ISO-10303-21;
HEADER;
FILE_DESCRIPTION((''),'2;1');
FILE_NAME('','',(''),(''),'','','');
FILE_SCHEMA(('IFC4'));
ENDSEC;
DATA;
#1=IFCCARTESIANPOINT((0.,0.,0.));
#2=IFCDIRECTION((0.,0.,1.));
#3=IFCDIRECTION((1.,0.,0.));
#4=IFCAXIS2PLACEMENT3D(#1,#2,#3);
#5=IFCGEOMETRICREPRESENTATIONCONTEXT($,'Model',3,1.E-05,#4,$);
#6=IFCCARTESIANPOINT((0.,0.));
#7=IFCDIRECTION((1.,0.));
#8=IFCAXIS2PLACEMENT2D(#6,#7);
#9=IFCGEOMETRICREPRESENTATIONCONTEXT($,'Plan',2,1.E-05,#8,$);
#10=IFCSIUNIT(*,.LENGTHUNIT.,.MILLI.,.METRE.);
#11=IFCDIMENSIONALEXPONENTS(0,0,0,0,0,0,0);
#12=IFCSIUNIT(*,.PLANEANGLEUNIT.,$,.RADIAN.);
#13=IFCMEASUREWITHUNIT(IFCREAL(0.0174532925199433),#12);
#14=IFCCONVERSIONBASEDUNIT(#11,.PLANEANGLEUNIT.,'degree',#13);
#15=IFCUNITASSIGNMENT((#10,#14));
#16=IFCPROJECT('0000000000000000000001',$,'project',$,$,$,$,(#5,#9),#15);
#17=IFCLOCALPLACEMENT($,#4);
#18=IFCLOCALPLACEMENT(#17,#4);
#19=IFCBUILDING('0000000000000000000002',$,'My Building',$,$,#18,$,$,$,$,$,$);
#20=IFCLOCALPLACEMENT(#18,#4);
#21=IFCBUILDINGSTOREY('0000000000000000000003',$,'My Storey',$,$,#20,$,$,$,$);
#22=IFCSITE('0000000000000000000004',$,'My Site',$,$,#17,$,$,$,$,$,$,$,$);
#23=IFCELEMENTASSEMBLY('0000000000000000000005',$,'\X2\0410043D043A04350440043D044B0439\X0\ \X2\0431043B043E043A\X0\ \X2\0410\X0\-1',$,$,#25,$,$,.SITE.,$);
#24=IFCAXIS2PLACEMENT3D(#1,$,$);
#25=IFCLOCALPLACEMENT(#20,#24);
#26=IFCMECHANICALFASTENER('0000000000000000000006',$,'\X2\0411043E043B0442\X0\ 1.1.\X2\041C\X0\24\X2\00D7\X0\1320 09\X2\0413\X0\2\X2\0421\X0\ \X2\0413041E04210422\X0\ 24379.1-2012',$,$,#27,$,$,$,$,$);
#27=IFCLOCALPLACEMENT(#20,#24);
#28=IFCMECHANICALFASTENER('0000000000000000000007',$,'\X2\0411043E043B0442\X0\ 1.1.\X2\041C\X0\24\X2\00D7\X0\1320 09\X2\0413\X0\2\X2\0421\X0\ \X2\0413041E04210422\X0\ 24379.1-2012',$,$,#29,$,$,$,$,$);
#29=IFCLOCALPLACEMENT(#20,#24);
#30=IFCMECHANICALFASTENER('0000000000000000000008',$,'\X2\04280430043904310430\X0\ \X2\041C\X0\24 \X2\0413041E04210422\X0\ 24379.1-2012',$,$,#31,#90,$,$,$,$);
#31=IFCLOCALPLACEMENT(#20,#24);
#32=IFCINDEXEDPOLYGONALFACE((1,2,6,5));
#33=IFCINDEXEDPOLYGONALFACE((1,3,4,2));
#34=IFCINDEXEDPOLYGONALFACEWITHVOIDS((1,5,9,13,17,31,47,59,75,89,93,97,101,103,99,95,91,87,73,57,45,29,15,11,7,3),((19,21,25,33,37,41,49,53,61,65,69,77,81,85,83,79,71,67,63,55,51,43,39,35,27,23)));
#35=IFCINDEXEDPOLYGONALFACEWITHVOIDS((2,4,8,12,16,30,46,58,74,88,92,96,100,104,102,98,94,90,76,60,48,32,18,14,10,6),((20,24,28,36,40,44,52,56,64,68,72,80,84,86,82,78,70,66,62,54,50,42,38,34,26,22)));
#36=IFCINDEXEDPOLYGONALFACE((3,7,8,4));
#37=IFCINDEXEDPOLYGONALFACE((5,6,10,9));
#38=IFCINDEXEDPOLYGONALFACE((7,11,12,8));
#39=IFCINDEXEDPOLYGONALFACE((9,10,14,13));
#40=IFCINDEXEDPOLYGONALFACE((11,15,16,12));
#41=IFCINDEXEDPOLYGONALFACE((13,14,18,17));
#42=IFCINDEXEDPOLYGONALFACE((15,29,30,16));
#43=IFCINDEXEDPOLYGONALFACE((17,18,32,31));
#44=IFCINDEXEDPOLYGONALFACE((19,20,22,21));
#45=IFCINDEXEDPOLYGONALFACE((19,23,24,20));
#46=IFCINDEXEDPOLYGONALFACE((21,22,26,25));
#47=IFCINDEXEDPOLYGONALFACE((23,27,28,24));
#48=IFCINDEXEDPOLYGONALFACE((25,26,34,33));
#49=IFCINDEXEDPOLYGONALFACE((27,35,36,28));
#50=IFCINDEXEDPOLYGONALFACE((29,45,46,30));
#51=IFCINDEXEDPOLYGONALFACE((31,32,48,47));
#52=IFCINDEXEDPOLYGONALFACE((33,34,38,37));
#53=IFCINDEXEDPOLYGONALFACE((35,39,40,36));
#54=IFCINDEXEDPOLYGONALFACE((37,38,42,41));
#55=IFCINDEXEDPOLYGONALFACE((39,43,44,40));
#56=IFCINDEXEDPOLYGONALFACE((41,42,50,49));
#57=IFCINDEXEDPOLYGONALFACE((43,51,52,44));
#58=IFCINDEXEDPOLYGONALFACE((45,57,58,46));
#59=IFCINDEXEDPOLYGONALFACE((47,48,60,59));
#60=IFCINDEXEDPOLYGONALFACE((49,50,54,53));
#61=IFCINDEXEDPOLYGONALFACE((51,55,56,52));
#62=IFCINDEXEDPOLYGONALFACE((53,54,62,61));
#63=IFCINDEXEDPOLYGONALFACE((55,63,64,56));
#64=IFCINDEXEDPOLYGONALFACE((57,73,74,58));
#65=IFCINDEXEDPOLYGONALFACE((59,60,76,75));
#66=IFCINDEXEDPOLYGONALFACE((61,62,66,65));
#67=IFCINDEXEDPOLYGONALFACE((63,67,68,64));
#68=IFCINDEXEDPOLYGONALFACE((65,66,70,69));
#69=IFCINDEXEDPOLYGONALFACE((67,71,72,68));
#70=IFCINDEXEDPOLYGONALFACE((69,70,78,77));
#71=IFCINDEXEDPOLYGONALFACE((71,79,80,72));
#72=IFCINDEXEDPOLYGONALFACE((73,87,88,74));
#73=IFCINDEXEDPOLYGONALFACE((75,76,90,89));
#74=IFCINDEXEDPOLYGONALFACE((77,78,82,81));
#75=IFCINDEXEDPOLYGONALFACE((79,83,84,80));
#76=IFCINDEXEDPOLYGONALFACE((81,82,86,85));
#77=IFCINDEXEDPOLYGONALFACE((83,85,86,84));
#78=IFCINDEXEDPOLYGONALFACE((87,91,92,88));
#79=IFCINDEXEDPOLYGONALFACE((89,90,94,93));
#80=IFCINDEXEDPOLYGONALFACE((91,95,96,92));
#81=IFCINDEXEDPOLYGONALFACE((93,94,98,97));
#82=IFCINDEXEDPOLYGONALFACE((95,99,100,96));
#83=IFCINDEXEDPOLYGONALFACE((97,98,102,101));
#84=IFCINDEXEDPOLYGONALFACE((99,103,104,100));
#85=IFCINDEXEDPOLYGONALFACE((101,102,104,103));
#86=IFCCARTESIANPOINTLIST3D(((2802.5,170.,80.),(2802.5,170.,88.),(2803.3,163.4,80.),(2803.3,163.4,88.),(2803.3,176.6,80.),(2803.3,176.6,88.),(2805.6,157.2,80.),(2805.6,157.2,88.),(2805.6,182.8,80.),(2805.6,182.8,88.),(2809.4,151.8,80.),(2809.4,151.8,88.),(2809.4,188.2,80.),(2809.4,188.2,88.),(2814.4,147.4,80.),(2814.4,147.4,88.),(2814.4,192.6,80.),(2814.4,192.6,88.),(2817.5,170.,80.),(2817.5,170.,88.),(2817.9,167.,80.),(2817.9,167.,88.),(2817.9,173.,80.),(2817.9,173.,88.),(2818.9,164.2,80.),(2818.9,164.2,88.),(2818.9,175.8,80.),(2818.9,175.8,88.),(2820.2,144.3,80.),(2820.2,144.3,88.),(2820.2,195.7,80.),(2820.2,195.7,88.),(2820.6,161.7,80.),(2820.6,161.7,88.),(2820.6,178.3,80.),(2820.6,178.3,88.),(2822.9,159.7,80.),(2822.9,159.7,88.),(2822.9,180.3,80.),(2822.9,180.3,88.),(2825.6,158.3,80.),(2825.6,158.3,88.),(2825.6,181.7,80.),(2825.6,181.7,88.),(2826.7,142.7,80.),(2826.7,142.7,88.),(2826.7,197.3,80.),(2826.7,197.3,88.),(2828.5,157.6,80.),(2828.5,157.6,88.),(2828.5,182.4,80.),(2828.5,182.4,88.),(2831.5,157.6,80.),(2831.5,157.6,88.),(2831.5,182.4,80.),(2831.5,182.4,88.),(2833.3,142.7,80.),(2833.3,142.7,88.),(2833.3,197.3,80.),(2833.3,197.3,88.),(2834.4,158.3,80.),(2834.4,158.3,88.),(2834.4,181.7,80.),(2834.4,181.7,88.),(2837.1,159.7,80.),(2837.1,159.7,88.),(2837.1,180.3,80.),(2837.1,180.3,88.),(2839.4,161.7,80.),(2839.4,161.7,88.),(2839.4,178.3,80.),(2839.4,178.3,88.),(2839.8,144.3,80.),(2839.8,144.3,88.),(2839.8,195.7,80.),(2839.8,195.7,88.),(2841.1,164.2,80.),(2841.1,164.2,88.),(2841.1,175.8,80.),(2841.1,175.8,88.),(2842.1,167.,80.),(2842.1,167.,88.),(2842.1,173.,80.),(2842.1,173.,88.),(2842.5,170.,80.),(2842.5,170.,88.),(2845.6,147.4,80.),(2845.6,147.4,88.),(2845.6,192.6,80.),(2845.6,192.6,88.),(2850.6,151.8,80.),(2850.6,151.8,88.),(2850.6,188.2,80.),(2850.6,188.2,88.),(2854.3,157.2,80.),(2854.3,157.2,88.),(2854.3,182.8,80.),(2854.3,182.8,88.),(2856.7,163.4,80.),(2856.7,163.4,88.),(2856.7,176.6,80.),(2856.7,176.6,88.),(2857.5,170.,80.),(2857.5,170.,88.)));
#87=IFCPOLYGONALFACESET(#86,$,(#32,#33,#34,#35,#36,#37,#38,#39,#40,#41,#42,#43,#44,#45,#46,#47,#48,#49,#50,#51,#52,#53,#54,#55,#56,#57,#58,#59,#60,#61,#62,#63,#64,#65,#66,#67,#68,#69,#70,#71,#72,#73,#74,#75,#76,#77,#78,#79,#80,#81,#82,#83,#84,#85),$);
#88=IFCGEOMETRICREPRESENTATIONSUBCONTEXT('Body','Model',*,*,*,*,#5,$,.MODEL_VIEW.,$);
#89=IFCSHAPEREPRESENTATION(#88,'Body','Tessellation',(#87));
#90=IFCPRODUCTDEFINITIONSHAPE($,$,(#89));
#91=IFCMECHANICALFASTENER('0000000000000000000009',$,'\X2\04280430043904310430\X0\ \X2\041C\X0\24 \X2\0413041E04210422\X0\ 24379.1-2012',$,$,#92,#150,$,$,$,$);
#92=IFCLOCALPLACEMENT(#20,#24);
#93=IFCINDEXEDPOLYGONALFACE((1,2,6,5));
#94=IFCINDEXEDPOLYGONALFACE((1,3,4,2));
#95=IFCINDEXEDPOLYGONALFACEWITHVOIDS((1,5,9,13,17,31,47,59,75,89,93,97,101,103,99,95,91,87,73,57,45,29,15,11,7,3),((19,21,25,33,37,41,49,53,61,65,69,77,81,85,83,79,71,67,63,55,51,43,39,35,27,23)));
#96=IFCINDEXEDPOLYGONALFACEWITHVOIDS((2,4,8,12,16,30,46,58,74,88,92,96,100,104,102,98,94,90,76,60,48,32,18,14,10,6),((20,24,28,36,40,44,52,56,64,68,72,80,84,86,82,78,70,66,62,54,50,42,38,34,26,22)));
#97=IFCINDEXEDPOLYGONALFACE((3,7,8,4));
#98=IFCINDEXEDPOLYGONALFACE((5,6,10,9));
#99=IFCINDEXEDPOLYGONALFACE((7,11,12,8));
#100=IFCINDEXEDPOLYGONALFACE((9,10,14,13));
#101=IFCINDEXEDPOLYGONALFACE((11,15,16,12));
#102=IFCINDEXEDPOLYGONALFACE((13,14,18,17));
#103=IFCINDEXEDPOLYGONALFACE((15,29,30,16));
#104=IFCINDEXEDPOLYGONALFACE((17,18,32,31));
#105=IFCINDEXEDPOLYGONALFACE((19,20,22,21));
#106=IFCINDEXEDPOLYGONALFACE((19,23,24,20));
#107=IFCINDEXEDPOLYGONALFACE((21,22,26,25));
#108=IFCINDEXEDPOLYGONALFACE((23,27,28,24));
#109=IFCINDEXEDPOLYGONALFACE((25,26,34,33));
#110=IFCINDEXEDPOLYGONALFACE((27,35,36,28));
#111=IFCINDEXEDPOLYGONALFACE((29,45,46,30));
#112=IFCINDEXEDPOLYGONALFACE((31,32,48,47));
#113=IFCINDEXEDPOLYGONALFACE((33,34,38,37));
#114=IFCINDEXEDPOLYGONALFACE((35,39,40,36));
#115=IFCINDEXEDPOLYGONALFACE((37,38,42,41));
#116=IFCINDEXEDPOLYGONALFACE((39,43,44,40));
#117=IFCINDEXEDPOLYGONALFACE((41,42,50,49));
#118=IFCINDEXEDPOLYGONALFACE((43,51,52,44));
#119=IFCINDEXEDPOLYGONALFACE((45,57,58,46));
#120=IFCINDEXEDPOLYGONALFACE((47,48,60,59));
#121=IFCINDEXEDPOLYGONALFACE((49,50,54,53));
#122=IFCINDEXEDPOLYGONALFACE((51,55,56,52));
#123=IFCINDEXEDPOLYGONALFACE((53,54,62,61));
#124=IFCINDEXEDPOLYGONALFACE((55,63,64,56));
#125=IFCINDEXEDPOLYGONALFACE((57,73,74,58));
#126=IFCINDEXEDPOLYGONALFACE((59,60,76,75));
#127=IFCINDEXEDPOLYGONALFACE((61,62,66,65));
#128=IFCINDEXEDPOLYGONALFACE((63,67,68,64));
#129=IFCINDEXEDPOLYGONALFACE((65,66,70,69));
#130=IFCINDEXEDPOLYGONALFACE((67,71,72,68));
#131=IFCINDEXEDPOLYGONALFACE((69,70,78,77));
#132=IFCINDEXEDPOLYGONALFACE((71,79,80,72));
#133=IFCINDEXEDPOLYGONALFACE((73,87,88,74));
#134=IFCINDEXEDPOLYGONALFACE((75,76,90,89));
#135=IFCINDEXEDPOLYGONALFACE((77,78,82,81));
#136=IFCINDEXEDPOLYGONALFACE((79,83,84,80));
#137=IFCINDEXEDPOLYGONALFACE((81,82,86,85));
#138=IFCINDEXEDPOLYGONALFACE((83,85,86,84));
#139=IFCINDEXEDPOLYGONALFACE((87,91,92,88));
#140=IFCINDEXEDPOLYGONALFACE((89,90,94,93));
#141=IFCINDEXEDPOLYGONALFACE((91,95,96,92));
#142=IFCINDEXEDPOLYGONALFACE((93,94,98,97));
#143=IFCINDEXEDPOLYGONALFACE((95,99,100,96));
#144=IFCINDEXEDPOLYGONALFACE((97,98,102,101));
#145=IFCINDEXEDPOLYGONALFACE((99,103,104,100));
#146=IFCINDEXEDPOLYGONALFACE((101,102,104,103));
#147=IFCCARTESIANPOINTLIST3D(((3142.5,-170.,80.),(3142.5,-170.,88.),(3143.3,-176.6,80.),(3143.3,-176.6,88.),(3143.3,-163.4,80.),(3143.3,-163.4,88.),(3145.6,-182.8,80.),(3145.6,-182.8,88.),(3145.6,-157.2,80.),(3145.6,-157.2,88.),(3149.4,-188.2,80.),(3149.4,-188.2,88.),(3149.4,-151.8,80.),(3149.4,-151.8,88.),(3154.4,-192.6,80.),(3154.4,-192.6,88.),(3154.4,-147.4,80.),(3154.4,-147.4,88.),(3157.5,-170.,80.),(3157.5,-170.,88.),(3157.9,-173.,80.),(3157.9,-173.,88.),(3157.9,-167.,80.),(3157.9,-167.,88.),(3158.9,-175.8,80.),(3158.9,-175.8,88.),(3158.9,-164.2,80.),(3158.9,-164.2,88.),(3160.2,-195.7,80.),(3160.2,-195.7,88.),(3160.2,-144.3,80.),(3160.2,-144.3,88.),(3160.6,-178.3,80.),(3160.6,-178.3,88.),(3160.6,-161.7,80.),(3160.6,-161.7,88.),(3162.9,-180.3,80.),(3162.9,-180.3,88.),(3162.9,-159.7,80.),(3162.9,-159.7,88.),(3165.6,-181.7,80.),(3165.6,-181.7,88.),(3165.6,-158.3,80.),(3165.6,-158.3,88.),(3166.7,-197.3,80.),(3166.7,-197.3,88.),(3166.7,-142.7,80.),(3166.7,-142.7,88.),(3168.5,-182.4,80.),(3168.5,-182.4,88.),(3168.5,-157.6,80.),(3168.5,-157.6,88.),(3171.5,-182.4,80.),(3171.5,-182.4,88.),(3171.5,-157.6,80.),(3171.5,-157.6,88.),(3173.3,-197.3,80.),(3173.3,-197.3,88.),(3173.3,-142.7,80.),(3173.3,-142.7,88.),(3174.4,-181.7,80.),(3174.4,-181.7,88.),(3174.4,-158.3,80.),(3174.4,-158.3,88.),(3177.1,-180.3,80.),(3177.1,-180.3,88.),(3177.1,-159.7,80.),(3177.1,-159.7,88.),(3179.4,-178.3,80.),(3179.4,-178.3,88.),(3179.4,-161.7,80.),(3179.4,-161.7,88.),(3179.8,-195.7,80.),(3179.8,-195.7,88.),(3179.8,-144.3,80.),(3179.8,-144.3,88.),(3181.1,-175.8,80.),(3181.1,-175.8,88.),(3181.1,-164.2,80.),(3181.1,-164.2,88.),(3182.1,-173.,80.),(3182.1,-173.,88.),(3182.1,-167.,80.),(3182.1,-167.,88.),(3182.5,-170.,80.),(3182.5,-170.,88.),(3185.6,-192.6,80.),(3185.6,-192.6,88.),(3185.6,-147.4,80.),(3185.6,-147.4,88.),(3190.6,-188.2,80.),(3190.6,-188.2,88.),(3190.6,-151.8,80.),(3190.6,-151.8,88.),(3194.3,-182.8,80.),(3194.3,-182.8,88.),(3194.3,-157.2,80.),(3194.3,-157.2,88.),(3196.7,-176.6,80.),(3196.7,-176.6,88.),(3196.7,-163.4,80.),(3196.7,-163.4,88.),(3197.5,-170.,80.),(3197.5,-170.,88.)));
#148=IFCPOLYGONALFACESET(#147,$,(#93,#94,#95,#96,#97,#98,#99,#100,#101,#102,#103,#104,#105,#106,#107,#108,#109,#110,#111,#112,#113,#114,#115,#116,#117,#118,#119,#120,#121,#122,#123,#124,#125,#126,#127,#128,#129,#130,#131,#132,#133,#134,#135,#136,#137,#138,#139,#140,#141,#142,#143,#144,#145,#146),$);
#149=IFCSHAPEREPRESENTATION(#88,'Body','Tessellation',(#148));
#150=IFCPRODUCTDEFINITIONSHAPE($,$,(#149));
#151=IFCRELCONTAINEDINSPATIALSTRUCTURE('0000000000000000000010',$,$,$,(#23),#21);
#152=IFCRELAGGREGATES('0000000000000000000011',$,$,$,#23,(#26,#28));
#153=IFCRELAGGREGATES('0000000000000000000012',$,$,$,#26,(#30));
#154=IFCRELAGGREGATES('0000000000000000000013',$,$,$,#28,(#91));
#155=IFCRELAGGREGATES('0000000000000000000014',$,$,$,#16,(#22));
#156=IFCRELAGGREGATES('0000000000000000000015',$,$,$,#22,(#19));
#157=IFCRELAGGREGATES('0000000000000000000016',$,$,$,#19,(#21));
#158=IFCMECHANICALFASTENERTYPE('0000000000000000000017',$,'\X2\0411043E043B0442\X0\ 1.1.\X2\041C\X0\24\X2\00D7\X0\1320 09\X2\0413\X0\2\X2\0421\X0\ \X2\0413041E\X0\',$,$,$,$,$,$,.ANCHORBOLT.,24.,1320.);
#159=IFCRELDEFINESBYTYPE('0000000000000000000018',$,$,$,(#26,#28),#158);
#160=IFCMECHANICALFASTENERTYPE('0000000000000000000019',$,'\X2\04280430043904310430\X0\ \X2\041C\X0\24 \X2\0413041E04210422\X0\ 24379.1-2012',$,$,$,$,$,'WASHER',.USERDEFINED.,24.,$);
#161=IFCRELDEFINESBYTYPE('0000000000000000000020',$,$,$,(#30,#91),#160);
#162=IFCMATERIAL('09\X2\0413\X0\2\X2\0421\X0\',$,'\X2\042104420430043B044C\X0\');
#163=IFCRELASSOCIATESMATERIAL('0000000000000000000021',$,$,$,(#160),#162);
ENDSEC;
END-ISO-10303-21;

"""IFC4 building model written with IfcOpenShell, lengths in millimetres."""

from ifc_helpers import new_model, entity, si_unit, converted_unit, frame, origin_with_axes, origin_2d_with_axis, place, context, subcontext, project, spatial, polyline, outline, extrude, source, transform, mapped, material, type_object, type_shapes, element, aggregate, save


model = new_model("IFC4")

# Units and contexts
model_context = context("Model", 3, precision=1e-05, world=origin_with_axes())
plan_context = context("Plan", 2, precision=1e-05, world=origin_2d_with_axis())
body_context = subcontext(model_context, "Body", "Model", "MODEL_VIEW")
ifc_project = project(units=[si_unit("LENGTHUNIT", "METRE", prefix="MILLI"), converted_unit("PLANEANGLEUNIT", "degree", entity("IfcReal", 0.0174532925199433), si_unit("PLANEANGLEUNIT", "RADIAN"), dimensions=[0, 0, 0, 0, 0, 0, 0])], contexts=[model_context, plan_context])

# Site, building, storey
site_placement = place(None, origin_with_axes())
site = spatial("IfcSite", under=ifc_project, at=site_placement, Name="My Site")
building_placement = place(site_placement, origin_with_axes())
building = spatial("IfcBuilding", under=site, at=building_placement, Name="My Building")
storey_placement = place(building_placement, origin_with_axes())
storey = spatial("IfcBuildingStorey", under=building, at=storey_placement, Name="My Storey")

# Element assembly, mechanical fasteners
assembly_placement = place(storey_placement, frame((3000.0, 0.0, 0.0), z_axis=(0.0, 0.0, 1.0), x_axis=(1.0, 0.0, 0.0)))
assembly = element("IfcElementAssembly", 1, at=assembly_placement, inside=storey, Name="Анкерный блок А-1", AssemblyPlace="SITE")
mechanical_fastener_type_1 = type_object("IfcMechanicalFastenerType", Name="Болт 1.1.М24×1320 09Г2С ГО", NominalDiameter=24.0, NominalLength=1320.0, PredefinedType="ANCHORBOLT")
mechanical_fastener_1_placement = place(assembly_placement, frame((-170.0, 170.0, 0.0), z_axis=(0.0, 0.0, 1.0), x_axis=(-1.0, 0.0, 0.0)))
mechanical_fastener_1 = element("IfcMechanicalFastener", 2, at=mechanical_fastener_1_placement, type_object=mechanical_fastener_type_1, Name="Болт 1.1.М24×1320 09Г2С ГОСТ 24379.1-2012")
ifc_material_1 = material(Name="09Г2С", Category="Сталь")
mechanical_fastener_2_placement = place(assembly_placement, frame((170.0, -170.0, 0.0), z_axis=(0.0, 0.0, 1.0), x_axis=(1.0, 0.0, 0.0)))
mechanical_fastener_2 = element("IfcMechanicalFastener", 3, at=mechanical_fastener_2_placement, type_object=mechanical_fastener_type_1, Name="Болт 1.1.М24×1320 09Г2С ГОСТ 24379.1-2012")
aggregate(assembly, [mechanical_fastener_1, mechanical_fastener_2])
mechanical_fastener_type_2 = type_object("IfcMechanicalFastenerType", Name="Шайба М24 ГОСТ 24379.1-2012", ElementType="WASHER", NominalDiameter=24.0, PredefinedType="USERDEFINED", material=ifc_material_1)
shared_shape_1 = source(origin_with_axes(), body_context, "Body", "SweptSolid", [
    extrude(outline(polyline([(27.5, 0.0), (26.7, 6.6), (24.4, 12.8), (20.6, 18.2), (15.6, 22.6), (9.8, 25.7), (3.3, 27.3), (-3.3, 27.3), (-9.8, 25.7), (-15.6, 22.6), (-20.6, 18.2), (-24.4, 12.8), (-26.7, 6.6), (-27.5, 0.0), (-26.7, -6.6), (-24.4, -12.8), (-20.6, -18.2), (-15.6, -22.6), (-9.8, -25.7), (-3.3, -27.3), (3.3, -27.3), (9.8, -25.7), (15.6, -22.6), (20.6, -18.2), (24.4, -12.8), (26.7, -6.6), (27.5, 0.0)]), holes=[polyline([(-4.4, -11.7), (-7.1, -10.3), (-9.4, -8.3), (-11.1, -5.8), (-12.1, -3.0), (-12.5, 0.0), (-12.1, 3.0), (-11.1, 5.8), (-9.4, 8.3), (-7.1, 10.3), (-4.4, 11.7), (-1.5, 12.4), (1.5, 12.4), (4.4, 11.7), (7.1, 10.3), (9.4, 8.3), (11.1, 5.8), (12.1, 3.0), (12.5, 0.0), (12.1, -3.0), (11.1, -5.8), (9.4, -8.3), (7.1, -10.3), (4.4, -11.7), (1.5, -12.4), (-1.5, -12.4), (-4.4, -11.7)])]), frame((0.0, 0.0, 0.0), z_axis=(0.0, 0.0, 1.0), x_axis=(0.120537, -0.992709, 0.0)), (0.0, 0.0, 1.0), 8.0),
])
type_shapes(mechanical_fastener_type_2, [shared_shape_1])
mechanical_fastener_3_placement = place(mechanical_fastener_1_placement, frame((0.0, 0.0, 80.0), z_axis=(0.0, 0.0, 1.0), x_axis=(1.0, 0.0, 0.0)))
mechanical_fastener_3 = element("IfcMechanicalFastener", 4, at=mechanical_fastener_3_placement, type_object=mechanical_fastener_type_2, Name="Шайба М24 ГОСТ 24379.1-2012", context=body_context, shape_type="MappedRepresentation", body=[
    mapped(shared_shape_1, transform((0.0, 0.0, 0.0), x_axis=(1.0, 0.0, 0.0), y_axis=(0.0, 1.0, 0.0), z_axis=(0.0, 0.0, 1.0), scale=1.0)),
])
aggregate(mechanical_fastener_1, [mechanical_fastener_3])
mechanical_fastener_4_placement = place(mechanical_fastener_2_placement, frame((0.0, 0.0, 80.0), z_axis=(0.0, 0.0, 1.0), x_axis=(1.0, 0.0, 0.0)))
mechanical_fastener_4 = element("IfcMechanicalFastener", 5, at=mechanical_fastener_4_placement, type_object=mechanical_fastener_type_2, Name="Шайба М24 ГОСТ 24379.1-2012", context=body_context, shape_type="MappedRepresentation", body=[
    mapped(shared_shape_1, transform((0.0, 0.0, 0.0), x_axis=(1.0, 0.0, 0.0), y_axis=(0.0, 1.0, 0.0), z_axis=(0.0, 0.0, 1.0), scale=1.0)),
])
aggregate(mechanical_fastener_2, [mechanical_fastener_4])

save(model, "model.ifc")
